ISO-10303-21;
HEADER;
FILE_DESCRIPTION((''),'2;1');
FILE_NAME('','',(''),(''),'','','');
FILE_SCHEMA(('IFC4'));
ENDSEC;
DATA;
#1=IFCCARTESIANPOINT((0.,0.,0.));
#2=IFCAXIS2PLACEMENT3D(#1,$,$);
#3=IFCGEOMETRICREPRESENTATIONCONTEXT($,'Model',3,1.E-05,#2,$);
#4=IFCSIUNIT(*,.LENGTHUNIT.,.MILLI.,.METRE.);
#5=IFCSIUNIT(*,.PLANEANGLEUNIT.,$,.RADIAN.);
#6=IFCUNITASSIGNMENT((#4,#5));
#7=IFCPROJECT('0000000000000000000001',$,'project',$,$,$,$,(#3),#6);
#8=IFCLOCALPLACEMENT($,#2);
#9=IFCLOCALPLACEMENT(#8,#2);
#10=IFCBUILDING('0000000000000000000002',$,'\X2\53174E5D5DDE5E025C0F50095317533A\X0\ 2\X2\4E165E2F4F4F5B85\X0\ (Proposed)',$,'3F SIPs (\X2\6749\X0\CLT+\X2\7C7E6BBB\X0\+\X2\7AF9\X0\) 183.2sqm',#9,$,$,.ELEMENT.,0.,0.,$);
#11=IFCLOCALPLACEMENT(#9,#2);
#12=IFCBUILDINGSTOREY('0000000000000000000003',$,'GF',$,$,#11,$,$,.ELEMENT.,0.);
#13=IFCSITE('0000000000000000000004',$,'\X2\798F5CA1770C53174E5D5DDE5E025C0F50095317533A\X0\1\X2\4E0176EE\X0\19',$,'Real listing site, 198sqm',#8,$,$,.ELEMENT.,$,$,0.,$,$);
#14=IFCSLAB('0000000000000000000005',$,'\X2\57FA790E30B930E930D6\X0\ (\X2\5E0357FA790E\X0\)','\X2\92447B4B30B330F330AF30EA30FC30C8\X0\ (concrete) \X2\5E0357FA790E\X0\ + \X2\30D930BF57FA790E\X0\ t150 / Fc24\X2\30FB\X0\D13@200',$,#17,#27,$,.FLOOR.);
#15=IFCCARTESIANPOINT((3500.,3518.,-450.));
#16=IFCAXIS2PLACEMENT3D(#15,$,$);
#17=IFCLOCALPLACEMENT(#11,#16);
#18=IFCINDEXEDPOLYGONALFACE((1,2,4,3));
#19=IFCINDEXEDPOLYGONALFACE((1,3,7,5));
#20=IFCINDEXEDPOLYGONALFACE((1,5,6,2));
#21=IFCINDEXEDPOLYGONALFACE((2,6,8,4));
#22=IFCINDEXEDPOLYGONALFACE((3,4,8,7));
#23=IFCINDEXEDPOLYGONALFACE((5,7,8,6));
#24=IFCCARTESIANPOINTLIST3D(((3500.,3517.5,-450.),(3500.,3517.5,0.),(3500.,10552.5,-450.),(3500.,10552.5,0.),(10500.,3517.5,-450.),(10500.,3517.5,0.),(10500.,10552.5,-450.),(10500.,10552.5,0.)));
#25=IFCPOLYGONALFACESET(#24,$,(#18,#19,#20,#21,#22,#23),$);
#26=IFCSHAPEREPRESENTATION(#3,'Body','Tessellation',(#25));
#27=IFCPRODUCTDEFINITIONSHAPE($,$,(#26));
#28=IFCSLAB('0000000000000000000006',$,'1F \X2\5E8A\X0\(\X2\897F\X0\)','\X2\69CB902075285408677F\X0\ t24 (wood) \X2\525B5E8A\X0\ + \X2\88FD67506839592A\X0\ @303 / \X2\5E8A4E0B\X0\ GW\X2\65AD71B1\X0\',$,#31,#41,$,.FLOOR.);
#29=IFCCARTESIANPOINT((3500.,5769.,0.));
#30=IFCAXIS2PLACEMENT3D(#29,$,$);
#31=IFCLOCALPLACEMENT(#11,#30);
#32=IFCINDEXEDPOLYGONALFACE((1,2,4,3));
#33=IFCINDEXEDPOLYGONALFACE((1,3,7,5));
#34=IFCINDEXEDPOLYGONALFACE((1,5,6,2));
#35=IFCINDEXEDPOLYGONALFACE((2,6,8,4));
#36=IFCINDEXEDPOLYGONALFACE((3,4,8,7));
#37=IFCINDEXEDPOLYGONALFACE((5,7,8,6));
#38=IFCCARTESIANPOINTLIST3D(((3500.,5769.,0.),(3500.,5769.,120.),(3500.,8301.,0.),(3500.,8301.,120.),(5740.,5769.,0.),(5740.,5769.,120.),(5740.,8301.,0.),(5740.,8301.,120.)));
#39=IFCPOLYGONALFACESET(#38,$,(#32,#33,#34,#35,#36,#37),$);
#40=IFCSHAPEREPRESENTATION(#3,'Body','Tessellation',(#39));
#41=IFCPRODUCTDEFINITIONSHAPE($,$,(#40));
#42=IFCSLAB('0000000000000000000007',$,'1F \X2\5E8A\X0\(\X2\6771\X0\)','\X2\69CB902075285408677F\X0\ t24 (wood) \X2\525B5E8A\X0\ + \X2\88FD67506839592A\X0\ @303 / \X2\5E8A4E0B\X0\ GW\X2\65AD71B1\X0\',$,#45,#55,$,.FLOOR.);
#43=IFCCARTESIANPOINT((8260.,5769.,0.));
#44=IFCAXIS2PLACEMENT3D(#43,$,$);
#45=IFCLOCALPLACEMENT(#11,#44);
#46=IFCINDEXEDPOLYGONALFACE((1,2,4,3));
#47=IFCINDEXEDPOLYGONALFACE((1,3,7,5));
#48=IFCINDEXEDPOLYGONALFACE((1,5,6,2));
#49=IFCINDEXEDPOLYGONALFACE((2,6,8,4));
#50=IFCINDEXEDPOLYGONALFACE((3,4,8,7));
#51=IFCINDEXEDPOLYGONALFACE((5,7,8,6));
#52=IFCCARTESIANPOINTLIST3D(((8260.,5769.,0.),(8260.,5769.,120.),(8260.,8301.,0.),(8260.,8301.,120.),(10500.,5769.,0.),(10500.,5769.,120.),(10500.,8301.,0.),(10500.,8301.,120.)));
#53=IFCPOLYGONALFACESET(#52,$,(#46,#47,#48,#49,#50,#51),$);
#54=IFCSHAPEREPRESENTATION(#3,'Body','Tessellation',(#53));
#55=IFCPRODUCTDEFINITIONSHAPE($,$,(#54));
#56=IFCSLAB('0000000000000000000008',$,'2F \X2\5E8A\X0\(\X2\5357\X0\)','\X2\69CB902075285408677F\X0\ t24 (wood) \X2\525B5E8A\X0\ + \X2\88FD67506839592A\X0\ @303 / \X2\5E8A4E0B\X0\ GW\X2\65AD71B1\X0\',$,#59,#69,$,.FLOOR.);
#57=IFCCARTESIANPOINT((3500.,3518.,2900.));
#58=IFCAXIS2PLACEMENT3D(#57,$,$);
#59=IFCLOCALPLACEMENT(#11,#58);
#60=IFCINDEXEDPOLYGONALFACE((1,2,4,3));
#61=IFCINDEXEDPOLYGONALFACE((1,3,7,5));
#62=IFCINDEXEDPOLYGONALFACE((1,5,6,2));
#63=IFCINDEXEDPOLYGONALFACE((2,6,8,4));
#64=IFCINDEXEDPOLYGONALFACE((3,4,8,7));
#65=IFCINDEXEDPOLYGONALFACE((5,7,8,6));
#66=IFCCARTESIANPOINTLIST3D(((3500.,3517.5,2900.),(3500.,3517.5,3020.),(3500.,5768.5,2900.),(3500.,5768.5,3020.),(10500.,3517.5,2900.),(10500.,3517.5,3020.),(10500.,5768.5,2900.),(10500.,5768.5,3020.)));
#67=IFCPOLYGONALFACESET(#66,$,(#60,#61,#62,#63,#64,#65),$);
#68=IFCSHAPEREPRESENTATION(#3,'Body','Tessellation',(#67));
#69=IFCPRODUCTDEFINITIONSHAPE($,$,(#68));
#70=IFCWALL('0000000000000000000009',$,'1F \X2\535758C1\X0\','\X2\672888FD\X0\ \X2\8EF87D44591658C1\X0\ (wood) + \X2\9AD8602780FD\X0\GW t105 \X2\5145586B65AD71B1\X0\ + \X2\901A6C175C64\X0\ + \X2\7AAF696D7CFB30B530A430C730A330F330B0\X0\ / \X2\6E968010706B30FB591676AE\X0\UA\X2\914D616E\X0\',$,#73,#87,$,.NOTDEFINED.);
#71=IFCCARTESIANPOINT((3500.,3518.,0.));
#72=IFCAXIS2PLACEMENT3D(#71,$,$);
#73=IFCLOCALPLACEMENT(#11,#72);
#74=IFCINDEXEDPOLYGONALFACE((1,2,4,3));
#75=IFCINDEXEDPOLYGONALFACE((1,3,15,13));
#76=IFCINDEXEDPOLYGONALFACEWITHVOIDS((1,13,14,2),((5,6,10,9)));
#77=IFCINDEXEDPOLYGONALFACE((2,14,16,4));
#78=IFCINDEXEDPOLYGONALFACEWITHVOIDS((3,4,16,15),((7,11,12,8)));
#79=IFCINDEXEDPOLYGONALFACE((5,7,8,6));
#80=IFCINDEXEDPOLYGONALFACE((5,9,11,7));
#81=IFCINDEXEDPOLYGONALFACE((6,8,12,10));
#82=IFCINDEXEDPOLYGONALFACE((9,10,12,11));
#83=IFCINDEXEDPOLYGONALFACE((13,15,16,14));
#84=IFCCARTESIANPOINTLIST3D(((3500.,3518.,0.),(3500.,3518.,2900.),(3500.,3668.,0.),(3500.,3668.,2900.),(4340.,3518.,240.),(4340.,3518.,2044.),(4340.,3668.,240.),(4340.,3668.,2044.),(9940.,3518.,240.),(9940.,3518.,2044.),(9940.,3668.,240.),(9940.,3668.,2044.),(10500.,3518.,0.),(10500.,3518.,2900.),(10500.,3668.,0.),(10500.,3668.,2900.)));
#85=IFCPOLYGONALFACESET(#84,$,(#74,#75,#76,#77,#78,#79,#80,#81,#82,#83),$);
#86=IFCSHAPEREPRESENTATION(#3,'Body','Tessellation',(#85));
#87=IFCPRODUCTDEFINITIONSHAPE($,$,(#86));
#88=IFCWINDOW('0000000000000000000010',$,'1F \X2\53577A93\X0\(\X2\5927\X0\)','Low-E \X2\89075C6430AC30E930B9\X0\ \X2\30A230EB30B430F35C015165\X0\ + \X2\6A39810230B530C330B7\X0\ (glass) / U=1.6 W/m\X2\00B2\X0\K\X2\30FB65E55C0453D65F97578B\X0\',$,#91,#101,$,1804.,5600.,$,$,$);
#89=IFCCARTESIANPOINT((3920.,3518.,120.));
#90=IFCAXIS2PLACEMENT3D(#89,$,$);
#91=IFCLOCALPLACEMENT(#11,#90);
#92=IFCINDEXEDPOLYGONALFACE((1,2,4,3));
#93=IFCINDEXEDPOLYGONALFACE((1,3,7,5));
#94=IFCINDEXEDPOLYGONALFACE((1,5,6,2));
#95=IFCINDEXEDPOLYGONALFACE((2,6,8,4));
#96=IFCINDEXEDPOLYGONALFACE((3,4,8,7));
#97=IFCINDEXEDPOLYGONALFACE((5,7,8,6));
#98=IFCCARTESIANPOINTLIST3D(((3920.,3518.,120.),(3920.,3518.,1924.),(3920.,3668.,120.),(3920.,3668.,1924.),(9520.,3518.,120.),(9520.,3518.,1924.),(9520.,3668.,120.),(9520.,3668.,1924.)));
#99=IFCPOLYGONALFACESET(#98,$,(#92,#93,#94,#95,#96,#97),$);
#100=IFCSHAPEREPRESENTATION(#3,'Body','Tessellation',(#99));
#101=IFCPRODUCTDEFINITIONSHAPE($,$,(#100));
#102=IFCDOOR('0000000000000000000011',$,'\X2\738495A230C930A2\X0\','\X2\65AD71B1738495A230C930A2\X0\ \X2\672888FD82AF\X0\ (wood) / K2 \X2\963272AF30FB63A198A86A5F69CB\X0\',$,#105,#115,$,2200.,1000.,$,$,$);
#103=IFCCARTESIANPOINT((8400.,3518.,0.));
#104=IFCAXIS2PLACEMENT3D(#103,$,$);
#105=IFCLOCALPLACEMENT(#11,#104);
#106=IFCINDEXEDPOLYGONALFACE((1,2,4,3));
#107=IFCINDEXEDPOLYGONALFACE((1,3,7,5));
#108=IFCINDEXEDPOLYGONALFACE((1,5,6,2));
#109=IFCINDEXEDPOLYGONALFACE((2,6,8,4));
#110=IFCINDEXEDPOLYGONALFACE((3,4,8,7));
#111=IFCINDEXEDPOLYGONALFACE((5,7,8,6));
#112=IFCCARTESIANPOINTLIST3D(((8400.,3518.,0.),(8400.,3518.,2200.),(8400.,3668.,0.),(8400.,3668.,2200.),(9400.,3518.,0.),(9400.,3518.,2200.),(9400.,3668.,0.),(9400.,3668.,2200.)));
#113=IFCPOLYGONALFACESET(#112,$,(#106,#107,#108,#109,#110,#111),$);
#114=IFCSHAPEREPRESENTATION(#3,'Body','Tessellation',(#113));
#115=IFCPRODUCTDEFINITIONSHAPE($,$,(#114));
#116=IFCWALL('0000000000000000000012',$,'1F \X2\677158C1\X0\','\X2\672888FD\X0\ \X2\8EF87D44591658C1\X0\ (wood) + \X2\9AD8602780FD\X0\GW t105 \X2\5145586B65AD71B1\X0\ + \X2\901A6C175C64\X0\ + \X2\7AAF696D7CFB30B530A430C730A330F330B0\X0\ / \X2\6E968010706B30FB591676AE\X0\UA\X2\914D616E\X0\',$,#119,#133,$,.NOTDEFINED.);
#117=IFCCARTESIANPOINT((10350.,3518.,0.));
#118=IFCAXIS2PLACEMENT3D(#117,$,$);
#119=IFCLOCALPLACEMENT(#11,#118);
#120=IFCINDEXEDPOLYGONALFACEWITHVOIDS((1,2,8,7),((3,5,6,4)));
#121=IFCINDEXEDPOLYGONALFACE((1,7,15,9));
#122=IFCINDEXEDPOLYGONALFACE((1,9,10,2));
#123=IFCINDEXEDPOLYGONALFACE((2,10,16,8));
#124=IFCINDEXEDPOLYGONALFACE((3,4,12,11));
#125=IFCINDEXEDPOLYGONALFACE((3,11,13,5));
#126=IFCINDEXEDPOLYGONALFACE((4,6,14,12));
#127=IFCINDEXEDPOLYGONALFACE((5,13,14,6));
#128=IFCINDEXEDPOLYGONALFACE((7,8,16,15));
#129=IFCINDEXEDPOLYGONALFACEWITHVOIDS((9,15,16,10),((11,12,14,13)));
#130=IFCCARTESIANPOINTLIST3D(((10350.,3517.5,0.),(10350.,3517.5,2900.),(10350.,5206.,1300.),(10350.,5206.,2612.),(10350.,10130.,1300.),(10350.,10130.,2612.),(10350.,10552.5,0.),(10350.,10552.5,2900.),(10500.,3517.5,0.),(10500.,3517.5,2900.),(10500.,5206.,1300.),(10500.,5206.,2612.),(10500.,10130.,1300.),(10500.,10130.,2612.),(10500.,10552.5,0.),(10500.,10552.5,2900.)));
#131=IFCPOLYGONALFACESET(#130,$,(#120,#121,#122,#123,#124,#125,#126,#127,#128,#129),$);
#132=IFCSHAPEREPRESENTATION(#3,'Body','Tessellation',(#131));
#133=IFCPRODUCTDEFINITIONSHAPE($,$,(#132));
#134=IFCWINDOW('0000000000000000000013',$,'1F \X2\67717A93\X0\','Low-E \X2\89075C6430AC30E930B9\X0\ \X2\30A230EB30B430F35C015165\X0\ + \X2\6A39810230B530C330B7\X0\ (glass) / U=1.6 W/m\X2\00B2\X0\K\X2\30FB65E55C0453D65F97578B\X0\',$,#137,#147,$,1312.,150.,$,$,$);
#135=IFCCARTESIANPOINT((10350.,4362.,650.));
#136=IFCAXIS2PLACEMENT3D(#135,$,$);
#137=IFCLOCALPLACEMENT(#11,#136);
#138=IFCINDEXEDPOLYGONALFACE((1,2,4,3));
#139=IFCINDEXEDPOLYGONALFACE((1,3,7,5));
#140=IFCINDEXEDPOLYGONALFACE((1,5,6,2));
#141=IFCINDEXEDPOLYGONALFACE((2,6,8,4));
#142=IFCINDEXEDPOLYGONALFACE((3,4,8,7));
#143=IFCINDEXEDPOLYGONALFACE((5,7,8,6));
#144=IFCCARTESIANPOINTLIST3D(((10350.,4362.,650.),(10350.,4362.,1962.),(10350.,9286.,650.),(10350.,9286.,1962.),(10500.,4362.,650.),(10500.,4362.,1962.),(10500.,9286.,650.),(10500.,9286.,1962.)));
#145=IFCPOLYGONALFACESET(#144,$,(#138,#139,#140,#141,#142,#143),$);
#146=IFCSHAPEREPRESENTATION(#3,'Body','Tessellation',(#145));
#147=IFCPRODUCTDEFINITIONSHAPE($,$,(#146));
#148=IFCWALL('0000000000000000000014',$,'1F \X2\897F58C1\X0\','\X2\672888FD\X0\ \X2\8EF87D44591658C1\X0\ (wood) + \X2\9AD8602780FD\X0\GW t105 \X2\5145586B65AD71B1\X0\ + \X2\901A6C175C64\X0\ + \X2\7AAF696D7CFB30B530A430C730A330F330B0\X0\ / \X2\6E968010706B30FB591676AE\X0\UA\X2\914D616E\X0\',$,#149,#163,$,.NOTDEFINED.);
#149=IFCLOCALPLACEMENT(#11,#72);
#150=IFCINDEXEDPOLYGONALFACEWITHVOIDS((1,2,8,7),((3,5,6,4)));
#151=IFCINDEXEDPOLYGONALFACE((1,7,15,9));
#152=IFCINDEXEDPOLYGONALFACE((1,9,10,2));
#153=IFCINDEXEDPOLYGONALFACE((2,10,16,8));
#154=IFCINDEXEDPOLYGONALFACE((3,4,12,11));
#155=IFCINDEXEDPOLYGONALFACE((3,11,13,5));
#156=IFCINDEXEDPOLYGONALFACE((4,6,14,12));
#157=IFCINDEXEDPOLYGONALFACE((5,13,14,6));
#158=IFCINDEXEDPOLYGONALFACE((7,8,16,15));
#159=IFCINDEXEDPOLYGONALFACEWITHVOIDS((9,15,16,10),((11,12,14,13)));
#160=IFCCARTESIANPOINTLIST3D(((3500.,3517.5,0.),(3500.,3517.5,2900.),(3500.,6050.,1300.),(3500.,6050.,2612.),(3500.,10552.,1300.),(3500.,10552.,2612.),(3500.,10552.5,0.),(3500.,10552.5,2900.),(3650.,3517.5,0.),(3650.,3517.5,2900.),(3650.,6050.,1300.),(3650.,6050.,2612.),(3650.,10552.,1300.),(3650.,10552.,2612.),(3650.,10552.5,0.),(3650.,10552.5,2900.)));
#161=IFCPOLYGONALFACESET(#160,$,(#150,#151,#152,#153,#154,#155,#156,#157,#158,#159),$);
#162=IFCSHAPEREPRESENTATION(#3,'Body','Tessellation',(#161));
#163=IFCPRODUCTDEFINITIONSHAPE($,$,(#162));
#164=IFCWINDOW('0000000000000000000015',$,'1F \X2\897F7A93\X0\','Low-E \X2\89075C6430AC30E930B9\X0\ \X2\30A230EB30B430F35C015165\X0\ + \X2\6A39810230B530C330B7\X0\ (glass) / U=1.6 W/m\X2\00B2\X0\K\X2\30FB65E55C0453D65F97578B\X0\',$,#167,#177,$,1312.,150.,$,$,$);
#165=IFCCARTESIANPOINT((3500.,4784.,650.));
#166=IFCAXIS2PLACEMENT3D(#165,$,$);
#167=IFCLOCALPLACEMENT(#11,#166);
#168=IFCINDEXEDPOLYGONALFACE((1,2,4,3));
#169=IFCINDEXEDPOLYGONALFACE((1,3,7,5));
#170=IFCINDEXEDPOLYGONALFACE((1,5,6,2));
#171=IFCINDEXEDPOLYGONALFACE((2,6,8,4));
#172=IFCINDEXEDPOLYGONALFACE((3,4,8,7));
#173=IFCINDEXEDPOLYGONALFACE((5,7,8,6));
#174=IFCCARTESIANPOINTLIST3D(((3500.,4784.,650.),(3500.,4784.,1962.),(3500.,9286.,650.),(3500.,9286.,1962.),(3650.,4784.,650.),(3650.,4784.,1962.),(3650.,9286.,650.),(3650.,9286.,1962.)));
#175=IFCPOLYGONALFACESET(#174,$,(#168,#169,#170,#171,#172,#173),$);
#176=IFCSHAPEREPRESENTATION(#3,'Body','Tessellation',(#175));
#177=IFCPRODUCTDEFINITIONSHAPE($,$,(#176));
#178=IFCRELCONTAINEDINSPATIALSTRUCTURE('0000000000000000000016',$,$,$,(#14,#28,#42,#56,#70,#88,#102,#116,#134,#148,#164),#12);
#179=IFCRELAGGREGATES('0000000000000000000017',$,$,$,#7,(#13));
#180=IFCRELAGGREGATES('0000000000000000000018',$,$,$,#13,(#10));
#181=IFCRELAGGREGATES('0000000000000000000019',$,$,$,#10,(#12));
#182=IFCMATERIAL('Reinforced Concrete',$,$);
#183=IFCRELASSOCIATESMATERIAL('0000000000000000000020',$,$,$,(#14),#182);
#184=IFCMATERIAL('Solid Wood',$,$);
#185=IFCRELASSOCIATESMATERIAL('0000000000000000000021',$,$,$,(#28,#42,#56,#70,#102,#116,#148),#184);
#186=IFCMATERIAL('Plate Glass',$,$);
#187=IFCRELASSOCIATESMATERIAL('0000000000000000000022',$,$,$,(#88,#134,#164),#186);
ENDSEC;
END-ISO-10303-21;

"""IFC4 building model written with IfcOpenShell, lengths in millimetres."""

from ifc_helpers import new_model, si_unit, frame, frame_2d, origin, place, context, project, spatial, rectangle, extrude, material, element, fill, save


model = new_model("IFC4")

# Units and contexts
model_context = context("Model", 3, precision=1e-05, world=origin())
ifc_project = project(units=[si_unit("LENGTHUNIT", "METRE", prefix="MILLI"), si_unit("PLANEANGLEUNIT", "RADIAN")], contexts=[model_context])

# Site, building, storey
site_placement = place(None, origin())
site = spatial("IfcSite", under=ifc_project, at=site_placement, Name="福岡県北九州市小倉北区1丁目19", ObjectType="Real listing site, 198sqm", CompositionType="ELEMENT", RefElevation=0.0)
building_placement = place(site_placement, origin())
building = spatial("IfcBuilding", under=site, at=building_placement, Name="北九州市小倉北区 2世帯住宅 (Proposed)", ObjectType="3F SIPs (杉CLT+籾殻+竹) 183.2sqm", CompositionType="ELEMENT", ElevationOfRefHeight=0.0, ElevationOfTerrain=0.0)
storey_placement = place(building_placement, origin())
storey = spatial("IfcBuildingStorey", under=building, at=storey_placement, Name="GF", CompositionType="ELEMENT", Elevation=0.0)

# Slabs
ifc_material_1 = material(Name="Reinforced Concrete")
slab_1_placement = place(storey_placement, frame((3500.0, 3518.0, -450.0)))
element("IfcSlab", 1, at=slab_1_placement, inside=storey, material=ifc_material_1, Name="基礎スラブ (布基礎)", Description="鉄筋コンクリート (concrete) 布基礎 + ベタ基礎 t150 / Fc24・D13@200", PredefinedType="FLOOR", context=model_context, shape_type="SweptSolid", body=[
    extrude(rectangle(XDim=7000.0, YDim=7035.0, at=frame_2d((3500.0, 3517.0))), frame((3500.0, 3518.0, -450.0)), (0.0, 0.0, 1.0), 450.0),
])
ifc_material_2 = material(Name="Solid Wood")
slab_2_placement = place(storey_placement, frame((3500.0, 5769.0, 0.0)))
element("IfcSlab", 2, at=slab_2_placement, inside=storey, material=ifc_material_2, Name="1F 床(西)", Description="構造用合板 t24 (wood) 剛床 + 製材根太 @303 / 床下 GW断熱", PredefinedType="FLOOR", context=model_context, shape_type="SweptSolid", body=[
    extrude(rectangle(XDim=2240.0, YDim=2532.0, at=frame_2d((1120.0, 1266.0))), frame((3500.0, 5769.0, 0.0)), (0.0, 0.0, 1.0), 120.0),
])
slab_3_placement = place(storey_placement, frame((8260.0, 5769.0, 0.0)))
element("IfcSlab", 3, at=slab_3_placement, inside=storey, material=ifc_material_2, Name="1F 床(東)", Description="構造用合板 t24 (wood) 剛床 + 製材根太 @303 / 床下 GW断熱", PredefinedType="FLOOR", context=model_context, shape_type="SweptSolid", body=[
    extrude(rectangle(XDim=2240.0, YDim=2532.0, at=frame_2d((1120.0, 1266.0))), frame((8260.0, 5769.0, 0.0)), (0.0, 0.0, 1.0), 120.0),
])
slab_4_placement = place(storey_placement, frame((3500.0, 3518.0, 2900.0)))
element("IfcSlab", 4, at=slab_4_placement, inside=storey, material=ifc_material_2, Name="2F 床(南)", Description="構造用合板 t24 (wood) 剛床 + 製材根太 @303 / 床下 GW断熱", PredefinedType="FLOOR", context=model_context, shape_type="SweptSolid", body=[
    extrude(rectangle(XDim=7000.0, YDim=2251.0, at=frame_2d((3500.0, 1125.0))), frame((3500.0, 3518.0, 2900.0)), (0.0, 0.0, 1.0), 120.0),
])

# Wall, openings, window, door
wall_1_placement = place(storey_placement, frame((3500.0, 3518.0, 0.0)))
wall_1 = element("IfcWall", 5, at=wall_1_placement, inside=storey, material=ifc_material_2, Name="1F 南壁", Description="木製 軸組外壁 (wood) + 高性能GW t105 充填断熱 + 通気層 + 窯業系サイディング / 準耐火・外皮UA配慮", PredefinedType="NOTDEFINED", context=model_context, shape_type="SweptSolid", body=[
    extrude(rectangle(XDim=7000.0, YDim=150.0, at=frame_2d((3500.0, 75.0))), frame((3500.0, 3518.0, 0.0)), (0.0, 0.0, 1.0), 2900.0),
])
opening_1_placement = place(storey_placement, frame((3920.0, 3518.0, 120.0)))
opening_1 = element("IfcOpeningElement", 6, at=opening_1_placement, cuts=wall_1, PredefinedType="NOTDEFINED", context=model_context, shape_type="SweptSolid", body=[
    extrude(rectangle(XDim=5600.0, YDim=150.0, at=frame_2d((2800.0, 75.0))), frame((3920.0, 3518.0, 120.0)), (0.0, 0.0, 1.0), 1804.0),
])
opening_2_placement = place(storey_placement, frame((8400.0, 3518.0, 0.0)))
opening_2 = element("IfcOpeningElement", 7, at=opening_2_placement, cuts=wall_1, PredefinedType="NOTDEFINED", context=model_context, shape_type="SweptSolid", body=[
    extrude(rectangle(XDim=1000.0, YDim=150.0, at=frame_2d((500.0, 75.0))), frame((8400.0, 3518.0, 0.0)), (0.0, 0.0, 1.0), 2200.0),
])
ifc_material_3 = material(Name="Plate Glass")
window_1_placement = place(storey_placement, frame((3920.0, 3518.0, 120.0)))
window_1 = element("IfcWindow", 8, at=window_1_placement, inside=storey, material=ifc_material_3, Name="1F 南窓(大)", Description="Low-E 複層ガラス アルゴン封入 + 樹脂サッシ (glass) / U=1.6 W/m²K・日射取得型", OverallHeight=1804.0, OverallWidth=5600.0, context=model_context, shape_type="SweptSolid", body=[
    extrude(rectangle(XDim=5600.0, YDim=150.0, at=frame_2d((2800.0, 75.0))), frame((3920.0, 3518.0, 120.0)), (0.0, 0.0, 1.0), 1804.0),
])
fill(opening_1, window_1)
door_placement = place(storey_placement, frame((8400.0, 3518.0, 0.0)))
door = element("IfcDoor", 9, at=door_placement, inside=storey, material=ifc_material_2, Name="玄関ドア", Description="断熱玄関ドア 木製芯 (wood) / K2 防犯・採風機構", OverallHeight=2200.0, OverallWidth=1000.0, context=model_context, shape_type="SweptSolid", body=[
    extrude(rectangle(XDim=1000.0, YDim=150.0, at=frame_2d((500.0, 75.0))), frame((8400.0, 3518.0, 0.0)), (0.0, 0.0, 1.0), 2200.0),
])
fill(opening_2, door)

# Walls, openings, windows
wall_2_placement = place(storey_placement, frame((10350.0, 3518.0, 0.0)))
wall_2 = element("IfcWall", 10, at=wall_2_placement, inside=storey, material=ifc_material_2, Name="1F 東壁", Description="木製 軸組外壁 (wood) + 高性能GW t105 充填断熱 + 通気層 + 窯業系サイディング / 準耐火・外皮UA配慮", PredefinedType="NOTDEFINED", context=model_context, shape_type="SweptSolid", body=[
    extrude(rectangle(XDim=150.0, YDim=7035.0, at=frame_2d((75.0, 3517.0))), frame((10350.0, 3518.0, 0.0)), (0.0, 0.0, 1.0), 2900.0),
])
opening_3_placement = place(storey_placement, frame((10350.0, 4362.0, 650.0)))
opening_3 = element("IfcOpeningElement", 11, at=opening_3_placement, cuts=wall_2, PredefinedType="NOTDEFINED", context=model_context, shape_type="SweptSolid", body=[
    extrude(rectangle(XDim=150.0, YDim=4924.0, at=frame_2d((75.0, 2462.0))), frame((10350.0, 4362.0, 650.0)), (0.0, 0.0, 1.0), 1312.0),
])
window_2_placement = place(storey_placement, frame((10350.0, 4362.0, 650.0)))
window_2 = element("IfcWindow", 12, at=window_2_placement, inside=storey, material=ifc_material_3, Name="1F 東窓", Description="Low-E 複層ガラス アルゴン封入 + 樹脂サッシ (glass) / U=1.6 W/m²K・日射取得型", OverallHeight=1312.0, OverallWidth=150.0, context=model_context, shape_type="SweptSolid", body=[
    extrude(rectangle(XDim=150.0, YDim=4924.0, at=frame_2d((75.0, 2462.0))), frame((10350.0, 4362.0, 650.0)), (0.0, 0.0, 1.0), 1312.0),
])
fill(opening_3, window_2)
wall_3_placement = place(storey_placement, frame((3500.0, 3518.0, 0.0)))
wall_3 = element("IfcWall", 13, at=wall_3_placement, inside=storey, material=ifc_material_2, Name="1F 西壁", Description="木製 軸組外壁 (wood) + 高性能GW t105 充填断熱 + 通気層 + 窯業系サイディング / 準耐火・外皮UA配慮", PredefinedType="NOTDEFINED", context=model_context, shape_type="SweptSolid", body=[
    extrude(rectangle(XDim=150.0, YDim=7035.0, at=frame_2d((75.0, 3517.0))), frame((3500.0, 3518.0, 0.0)), (0.0, 0.0, 1.0), 2900.0),
])
opening_4_placement = place(storey_placement, frame((3500.0, 4784.0, 650.0)))
opening_4 = element("IfcOpeningElement", 14, at=opening_4_placement, cuts=wall_3, PredefinedType="NOTDEFINED", context=model_context, shape_type="SweptSolid", body=[
    extrude(rectangle(XDim=150.0, YDim=4502.0, at=frame_2d((75.0, 2251.0))), frame((3500.0, 4784.0, 650.0)), (0.0, 0.0, 1.0), 1312.0),
])
window_3_placement = place(storey_placement, frame((3500.0, 4784.0, 650.0)))
window_3 = element("IfcWindow", 15, at=window_3_placement, inside=storey, material=ifc_material_3, Name="1F 西窓", Description="Low-E 複層ガラス アルゴン封入 + 樹脂サッシ (glass) / U=1.6 W/m²K・日射取得型", OverallHeight=1312.0, OverallWidth=150.0, context=model_context, shape_type="SweptSolid", body=[
    extrude(rectangle(XDim=150.0, YDim=4502.0, at=frame_2d((75.0, 2251.0))), frame((3500.0, 4784.0, 650.0)), (0.0, 0.0, 1.0), 1312.0),
])
fill(opening_4, window_3)

save(model, "model.ifc")
